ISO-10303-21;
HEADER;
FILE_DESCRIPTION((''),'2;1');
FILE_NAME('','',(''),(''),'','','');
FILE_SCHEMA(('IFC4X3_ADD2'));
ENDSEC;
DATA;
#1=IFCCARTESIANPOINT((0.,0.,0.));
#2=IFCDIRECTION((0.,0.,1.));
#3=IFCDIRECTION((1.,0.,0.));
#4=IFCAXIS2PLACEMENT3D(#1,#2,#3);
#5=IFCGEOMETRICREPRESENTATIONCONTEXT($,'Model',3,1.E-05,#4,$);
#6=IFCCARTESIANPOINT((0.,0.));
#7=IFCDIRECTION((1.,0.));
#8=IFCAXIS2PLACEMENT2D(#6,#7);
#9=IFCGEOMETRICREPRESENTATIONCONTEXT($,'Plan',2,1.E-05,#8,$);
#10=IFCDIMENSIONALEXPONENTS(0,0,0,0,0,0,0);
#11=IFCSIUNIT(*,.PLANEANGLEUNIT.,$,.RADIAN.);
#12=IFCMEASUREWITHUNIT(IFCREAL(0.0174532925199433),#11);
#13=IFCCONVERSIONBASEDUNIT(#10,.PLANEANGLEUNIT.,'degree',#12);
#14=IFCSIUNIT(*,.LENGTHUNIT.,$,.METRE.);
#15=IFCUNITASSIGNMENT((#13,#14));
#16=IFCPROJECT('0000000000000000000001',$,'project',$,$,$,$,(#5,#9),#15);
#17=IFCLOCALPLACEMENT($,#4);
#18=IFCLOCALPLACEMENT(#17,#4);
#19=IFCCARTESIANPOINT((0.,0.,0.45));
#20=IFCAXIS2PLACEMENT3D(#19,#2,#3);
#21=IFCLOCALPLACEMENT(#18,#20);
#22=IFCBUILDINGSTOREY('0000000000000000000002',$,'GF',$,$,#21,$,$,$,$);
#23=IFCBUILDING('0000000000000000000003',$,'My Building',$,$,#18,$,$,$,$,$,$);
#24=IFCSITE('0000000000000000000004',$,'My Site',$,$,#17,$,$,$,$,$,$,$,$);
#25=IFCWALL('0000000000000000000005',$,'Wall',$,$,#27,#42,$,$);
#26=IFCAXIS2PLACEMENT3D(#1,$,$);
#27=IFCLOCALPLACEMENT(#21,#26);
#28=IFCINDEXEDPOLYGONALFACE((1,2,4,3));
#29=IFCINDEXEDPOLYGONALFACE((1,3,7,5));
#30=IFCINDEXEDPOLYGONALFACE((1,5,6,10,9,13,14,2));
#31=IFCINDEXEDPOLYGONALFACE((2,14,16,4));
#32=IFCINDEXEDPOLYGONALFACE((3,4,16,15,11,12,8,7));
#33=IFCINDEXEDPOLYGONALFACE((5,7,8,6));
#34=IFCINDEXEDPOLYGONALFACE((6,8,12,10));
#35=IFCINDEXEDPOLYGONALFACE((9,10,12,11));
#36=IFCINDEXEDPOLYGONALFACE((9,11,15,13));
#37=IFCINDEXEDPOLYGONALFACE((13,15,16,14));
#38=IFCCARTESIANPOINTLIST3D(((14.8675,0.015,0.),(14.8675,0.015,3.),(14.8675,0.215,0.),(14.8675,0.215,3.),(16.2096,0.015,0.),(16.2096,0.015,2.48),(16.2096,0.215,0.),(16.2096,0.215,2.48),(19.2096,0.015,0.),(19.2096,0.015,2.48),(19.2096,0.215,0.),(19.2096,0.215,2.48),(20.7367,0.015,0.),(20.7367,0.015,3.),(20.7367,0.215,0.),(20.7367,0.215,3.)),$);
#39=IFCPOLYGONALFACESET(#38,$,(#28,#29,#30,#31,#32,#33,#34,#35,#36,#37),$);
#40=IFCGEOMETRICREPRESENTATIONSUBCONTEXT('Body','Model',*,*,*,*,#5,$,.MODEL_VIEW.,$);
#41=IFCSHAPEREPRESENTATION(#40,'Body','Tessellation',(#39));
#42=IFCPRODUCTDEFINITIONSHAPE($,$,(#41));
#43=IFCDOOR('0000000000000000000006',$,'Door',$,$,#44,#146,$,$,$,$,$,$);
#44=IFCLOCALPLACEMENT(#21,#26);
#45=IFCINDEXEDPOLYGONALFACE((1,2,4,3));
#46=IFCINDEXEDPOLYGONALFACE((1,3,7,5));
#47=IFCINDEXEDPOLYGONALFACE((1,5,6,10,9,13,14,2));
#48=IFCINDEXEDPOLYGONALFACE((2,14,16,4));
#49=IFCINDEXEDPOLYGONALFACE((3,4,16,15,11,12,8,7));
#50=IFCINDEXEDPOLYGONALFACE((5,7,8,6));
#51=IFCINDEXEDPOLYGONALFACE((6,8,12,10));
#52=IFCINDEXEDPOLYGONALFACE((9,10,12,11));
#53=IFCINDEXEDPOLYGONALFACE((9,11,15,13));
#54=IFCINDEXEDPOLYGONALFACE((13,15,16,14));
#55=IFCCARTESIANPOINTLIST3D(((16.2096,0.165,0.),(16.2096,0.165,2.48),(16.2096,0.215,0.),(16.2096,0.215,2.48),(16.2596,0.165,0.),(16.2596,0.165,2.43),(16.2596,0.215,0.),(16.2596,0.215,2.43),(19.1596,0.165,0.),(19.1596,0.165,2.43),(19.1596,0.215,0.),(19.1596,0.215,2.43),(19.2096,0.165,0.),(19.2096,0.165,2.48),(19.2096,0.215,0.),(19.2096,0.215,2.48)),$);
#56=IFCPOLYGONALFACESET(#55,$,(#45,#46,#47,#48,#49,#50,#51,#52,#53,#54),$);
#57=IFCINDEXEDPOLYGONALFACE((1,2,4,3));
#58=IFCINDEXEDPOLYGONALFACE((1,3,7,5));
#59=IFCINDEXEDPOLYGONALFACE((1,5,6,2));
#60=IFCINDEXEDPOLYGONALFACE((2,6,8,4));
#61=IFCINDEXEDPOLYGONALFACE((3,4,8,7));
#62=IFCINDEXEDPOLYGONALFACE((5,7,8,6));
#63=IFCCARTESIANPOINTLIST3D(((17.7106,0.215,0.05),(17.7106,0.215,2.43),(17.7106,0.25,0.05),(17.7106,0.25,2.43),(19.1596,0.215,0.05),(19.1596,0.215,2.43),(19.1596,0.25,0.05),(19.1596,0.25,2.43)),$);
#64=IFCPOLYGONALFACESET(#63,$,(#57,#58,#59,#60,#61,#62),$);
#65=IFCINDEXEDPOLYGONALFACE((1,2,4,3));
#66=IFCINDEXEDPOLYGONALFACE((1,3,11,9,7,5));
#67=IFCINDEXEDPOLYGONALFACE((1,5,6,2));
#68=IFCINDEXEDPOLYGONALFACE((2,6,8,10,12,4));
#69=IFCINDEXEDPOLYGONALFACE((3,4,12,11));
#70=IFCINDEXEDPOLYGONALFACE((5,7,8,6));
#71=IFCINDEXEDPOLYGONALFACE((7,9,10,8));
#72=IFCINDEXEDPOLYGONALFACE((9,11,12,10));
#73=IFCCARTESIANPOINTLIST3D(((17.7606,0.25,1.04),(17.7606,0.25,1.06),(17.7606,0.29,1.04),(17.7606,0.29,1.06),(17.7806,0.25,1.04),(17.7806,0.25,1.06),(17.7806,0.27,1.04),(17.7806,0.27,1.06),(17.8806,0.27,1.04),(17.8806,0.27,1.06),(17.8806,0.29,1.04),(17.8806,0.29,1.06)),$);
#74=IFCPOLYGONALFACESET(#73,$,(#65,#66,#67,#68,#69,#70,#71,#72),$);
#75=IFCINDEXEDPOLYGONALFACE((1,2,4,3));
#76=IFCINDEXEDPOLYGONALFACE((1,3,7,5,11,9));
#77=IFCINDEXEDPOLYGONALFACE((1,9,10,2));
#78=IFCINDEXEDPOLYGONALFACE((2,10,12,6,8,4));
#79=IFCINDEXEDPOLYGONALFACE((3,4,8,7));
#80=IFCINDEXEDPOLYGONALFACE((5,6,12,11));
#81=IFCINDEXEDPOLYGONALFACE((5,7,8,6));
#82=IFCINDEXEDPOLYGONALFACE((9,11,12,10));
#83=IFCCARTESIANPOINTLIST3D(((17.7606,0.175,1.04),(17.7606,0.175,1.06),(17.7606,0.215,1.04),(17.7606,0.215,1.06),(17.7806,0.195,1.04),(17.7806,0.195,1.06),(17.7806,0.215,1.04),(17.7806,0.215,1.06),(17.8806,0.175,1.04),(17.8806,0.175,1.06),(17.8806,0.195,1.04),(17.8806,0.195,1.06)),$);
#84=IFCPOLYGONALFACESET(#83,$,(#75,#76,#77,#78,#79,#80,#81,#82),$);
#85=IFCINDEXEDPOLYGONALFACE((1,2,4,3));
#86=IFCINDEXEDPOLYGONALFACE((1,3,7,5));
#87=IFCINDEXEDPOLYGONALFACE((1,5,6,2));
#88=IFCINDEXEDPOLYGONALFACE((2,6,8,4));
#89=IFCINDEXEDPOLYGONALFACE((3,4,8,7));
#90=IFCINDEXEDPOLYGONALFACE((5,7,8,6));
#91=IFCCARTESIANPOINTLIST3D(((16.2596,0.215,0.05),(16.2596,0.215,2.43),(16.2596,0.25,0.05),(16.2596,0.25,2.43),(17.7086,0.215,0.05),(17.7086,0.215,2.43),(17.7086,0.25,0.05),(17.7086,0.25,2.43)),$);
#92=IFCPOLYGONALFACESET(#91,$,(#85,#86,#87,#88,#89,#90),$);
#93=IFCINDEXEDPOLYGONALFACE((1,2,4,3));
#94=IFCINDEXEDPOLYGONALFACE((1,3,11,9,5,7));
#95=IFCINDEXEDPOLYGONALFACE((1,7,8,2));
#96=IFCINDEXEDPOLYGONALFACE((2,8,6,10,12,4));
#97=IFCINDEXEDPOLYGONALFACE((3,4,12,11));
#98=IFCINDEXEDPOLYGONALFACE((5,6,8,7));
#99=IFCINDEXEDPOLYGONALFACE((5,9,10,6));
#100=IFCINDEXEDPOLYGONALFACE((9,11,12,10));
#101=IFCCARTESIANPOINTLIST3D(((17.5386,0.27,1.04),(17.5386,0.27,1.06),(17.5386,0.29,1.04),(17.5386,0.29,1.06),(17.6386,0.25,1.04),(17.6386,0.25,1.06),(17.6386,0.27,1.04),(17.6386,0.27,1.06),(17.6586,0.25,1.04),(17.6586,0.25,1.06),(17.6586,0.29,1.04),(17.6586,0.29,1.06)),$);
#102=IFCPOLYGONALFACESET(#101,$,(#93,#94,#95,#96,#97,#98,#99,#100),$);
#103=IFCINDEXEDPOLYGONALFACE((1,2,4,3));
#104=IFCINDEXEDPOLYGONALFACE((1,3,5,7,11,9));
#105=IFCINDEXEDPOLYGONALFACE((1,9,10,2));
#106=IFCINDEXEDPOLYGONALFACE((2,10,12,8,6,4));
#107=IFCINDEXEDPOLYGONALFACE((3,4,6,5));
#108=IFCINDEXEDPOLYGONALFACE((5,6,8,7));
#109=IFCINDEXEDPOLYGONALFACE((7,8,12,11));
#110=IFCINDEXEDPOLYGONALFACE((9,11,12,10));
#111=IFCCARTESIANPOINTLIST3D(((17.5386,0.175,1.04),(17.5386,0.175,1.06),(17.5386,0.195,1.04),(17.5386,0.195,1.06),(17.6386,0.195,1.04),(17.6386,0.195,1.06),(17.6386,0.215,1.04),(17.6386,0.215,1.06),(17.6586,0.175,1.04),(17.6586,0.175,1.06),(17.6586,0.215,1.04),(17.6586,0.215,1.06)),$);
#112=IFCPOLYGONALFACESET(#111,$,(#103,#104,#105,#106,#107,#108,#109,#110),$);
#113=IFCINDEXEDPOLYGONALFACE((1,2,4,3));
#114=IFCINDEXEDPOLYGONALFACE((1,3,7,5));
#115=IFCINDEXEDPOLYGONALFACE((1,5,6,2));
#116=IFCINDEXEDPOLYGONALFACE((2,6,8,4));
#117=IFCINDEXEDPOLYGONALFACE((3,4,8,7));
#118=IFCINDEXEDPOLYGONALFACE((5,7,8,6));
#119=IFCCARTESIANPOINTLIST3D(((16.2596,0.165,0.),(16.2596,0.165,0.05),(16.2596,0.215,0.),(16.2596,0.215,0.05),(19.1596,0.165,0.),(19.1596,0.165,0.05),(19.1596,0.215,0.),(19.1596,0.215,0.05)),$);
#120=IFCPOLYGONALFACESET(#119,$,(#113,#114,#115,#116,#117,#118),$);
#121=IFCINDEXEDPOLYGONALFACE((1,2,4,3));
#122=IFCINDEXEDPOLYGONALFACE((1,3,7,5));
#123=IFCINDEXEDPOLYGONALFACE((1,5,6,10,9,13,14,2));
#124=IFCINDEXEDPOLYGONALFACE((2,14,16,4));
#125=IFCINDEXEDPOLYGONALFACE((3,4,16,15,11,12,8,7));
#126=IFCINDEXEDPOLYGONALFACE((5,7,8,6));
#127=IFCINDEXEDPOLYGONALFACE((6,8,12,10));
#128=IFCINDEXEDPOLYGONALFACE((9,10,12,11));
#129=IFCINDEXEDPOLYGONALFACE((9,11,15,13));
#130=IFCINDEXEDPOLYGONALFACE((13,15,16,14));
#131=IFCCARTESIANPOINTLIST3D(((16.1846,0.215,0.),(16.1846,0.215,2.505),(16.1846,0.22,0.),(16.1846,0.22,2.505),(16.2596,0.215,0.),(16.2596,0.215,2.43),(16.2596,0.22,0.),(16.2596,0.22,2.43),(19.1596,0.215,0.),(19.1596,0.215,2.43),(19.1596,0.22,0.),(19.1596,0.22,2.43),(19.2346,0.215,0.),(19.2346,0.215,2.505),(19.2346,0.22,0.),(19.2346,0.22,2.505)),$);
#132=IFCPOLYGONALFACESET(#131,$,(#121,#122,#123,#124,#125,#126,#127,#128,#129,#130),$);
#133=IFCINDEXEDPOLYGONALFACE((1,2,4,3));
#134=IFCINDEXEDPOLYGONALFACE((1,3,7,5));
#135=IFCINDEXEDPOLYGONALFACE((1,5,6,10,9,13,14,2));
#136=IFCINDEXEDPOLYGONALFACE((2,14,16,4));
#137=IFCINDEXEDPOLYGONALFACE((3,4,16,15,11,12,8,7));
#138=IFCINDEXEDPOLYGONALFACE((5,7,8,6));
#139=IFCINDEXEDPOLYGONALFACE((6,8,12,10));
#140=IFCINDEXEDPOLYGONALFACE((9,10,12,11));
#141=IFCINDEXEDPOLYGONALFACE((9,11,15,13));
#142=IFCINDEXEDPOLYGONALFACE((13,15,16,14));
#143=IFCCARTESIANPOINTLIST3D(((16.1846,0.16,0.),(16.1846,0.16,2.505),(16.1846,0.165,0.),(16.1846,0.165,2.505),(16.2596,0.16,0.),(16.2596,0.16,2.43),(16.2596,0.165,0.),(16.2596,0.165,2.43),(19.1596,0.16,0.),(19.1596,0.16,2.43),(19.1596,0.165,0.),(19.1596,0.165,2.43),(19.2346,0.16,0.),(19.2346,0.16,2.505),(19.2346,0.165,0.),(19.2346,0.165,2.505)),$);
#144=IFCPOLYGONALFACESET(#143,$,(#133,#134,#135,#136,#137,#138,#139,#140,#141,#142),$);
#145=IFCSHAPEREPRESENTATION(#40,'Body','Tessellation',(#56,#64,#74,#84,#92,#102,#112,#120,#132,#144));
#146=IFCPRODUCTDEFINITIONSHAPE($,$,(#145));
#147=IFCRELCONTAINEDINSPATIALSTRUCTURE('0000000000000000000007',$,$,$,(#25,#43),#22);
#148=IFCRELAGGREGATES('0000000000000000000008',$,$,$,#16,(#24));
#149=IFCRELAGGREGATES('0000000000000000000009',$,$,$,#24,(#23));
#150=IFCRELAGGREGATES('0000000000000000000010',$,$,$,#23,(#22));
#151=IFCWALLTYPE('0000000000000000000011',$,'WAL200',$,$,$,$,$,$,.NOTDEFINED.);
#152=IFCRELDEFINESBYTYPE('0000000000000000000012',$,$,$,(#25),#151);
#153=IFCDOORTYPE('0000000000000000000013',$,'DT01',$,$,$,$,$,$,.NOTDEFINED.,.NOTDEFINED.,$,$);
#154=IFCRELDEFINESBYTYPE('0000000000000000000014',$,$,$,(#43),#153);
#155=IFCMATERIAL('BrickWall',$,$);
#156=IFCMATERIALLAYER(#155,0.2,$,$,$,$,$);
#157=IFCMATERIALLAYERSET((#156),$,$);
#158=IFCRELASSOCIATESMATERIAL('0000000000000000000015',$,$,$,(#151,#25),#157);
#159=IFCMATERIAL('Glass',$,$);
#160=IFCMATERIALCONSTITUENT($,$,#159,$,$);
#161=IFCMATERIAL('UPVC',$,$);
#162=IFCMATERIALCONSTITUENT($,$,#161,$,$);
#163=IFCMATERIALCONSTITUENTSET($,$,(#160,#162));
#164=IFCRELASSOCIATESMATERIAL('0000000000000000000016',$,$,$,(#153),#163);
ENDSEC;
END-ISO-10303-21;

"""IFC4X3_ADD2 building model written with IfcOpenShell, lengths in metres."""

from ifc_helpers import new_model, entity, si_unit, converted_unit, frame, origin_with_axes, origin_2d_with_axis, place, context, subcontext, project, spatial, line, indexed_curve, outline, extrude, shape, source, transform, mapped, material, layer, layer_set, layer_usage, constituent, constituent_set, type_object, type_shapes, element, fill, save


model = new_model("IFC4X3_ADD2")

# Units and contexts
model_context = context("Model", 3, precision=1e-05, world=origin_with_axes())
plan_context = context("Plan", 2, precision=1e-05, world=origin_2d_with_axis())
body_context_1 = subcontext(model_context, "Body", "Model", "MODEL_VIEW")
body_context_2 = subcontext(plan_context, "Body", "Plan", "PLAN_VIEW")
ifc_project = project(units=[converted_unit("PLANEANGLEUNIT", "degree", entity("IfcReal", 0.0174532925199433), si_unit("PLANEANGLEUNIT", "RADIAN"), dimensions=[0, 0, 0, 0, 0, 0, 0]), si_unit("LENGTHUNIT", "METRE")], contexts=[model_context, plan_context])

# Site, building, storey
site_placement = place(None, origin_with_axes())
site = spatial("IfcSite", under=ifc_project, at=site_placement, Name="My Site")
building_placement = place(site_placement, origin_with_axes())
building = spatial("IfcBuilding", under=site, at=building_placement, Name="My Building")
storey_placement = place(building_placement, frame((0.0, 0.0, 0.45), z_axis=(0.0, 0.0, 1.0), x_axis=(1.0, 0.0, 0.0)))
storey = spatial("IfcBuildingStorey", under=building, at=storey_placement, Name="GF")

# Shared definitions
ifc_material_1 = material(Name="BrickWall")
ifc_layer_1 = layer(ifc_material_1, 0.2)
ifc_layer_set_1 = layer_set([ifc_layer_1])
wall_type_1 = type_object("IfcWallType", Name="WAL200", PredefinedType="NOTDEFINED", material=ifc_layer_set_1)
shared_shape_1 = source(origin_with_axes(), body_context_1, "Body", "SweptSolid", [
    extrude(outline(indexed_curve([(0.0, 0.0), (3.0, 0.0), (3.0, 2.48), (0.0, 2.48)], segments=[line(1, 2, 3, 4, 1)])), frame((0.0, -0.6, 0.0), z_axis=(0.0, -1.0, 0.0), x_axis=(1.0, 0.0, 0.0)), (0.0, 0.0, -1.0), 1.2),
])
ifc_material_2 = material(Name="Glass")
ifc_constituent_1 = constituent(ifc_material_2)
ifc_material_3 = material(Name="UPVC")
ifc_constituent_2 = constituent(ifc_material_3)
ifc_constituent_set = constituent_set(constituents=[ifc_constituent_1, ifc_constituent_2])
door_type_1 = type_object("IfcDoorType", Name="DT01", OperationType="NOTDEFINED", PredefinedType="NOTDEFINED", material=ifc_constituent_set)
shared_shape_2 = source(origin_with_axes(), body_context_1, "Body", "SweptSolid", [
    extrude(outline(indexed_curve([(3.0, 0.0), (3.0, 2.48), (0.0, 2.48), (0.0, 0.0), (0.05, 0.0), (0.05, 2.43), (2.95, 2.43), (2.95, 0.0)], segments=[line(5, 4), line(4, 3), line(3, 2), line(2, 1), line(1, 8), line(8, 7), line(7, 6), line(6, 5)], self_intersect=False)), frame((0.0, 0.0, 0.0), z_axis=(0.0, -1.0, 0.0), x_axis=(1.0, 0.0, 0.0)), (0.0, 0.0, -1.0), 0.05),
    extrude(outline(indexed_curve([(0.0, 0.0), (1.449, 0.0), (1.449, 0.035), (0.0, 0.035)], segments=[line(1, 2, 3, 4, 1)])), frame((0.05, -0.035, 0.05), z_axis=(0.0, 0.0, 1.0), x_axis=(1.0, 0.0, 0.0)), (0.0, 0.0, 1.0), 2.38),
    extrude(outline(indexed_curve([(0.0, 0.0), (0.0, -0.04), (-0.12, -0.04), (-0.12, -0.02), (-0.02, -0.02), (-0.02, 0.0)], segments=[line(1, 2, 3, 4, 5, 6, 1)])), frame((1.449, -0.035, 1.04), z_axis=(0.0, 0.0, 1.0), x_axis=(1.0, 0.0, 0.0)), (0.0, 0.0, 1.0), 0.02),
    extrude(outline(indexed_curve([(0.0, 0.0), (0.0, 0.04), (-0.12, 0.04), (-0.12, 0.02), (-0.02, 0.02), (-0.02, 0.0)], segments=[line(1, 2, 3, 4, 5, 6, 1)])), frame((1.449, 0.0, 1.04), z_axis=(0.0, 0.0, 1.0), x_axis=(1.0, 0.0, 0.0)), (0.0, 0.0, 1.0), 0.02),
    extrude(outline(indexed_curve([(0.0, 0.0), (-1.449, 0.0), (-1.449, 0.035), (0.0, 0.035)], segments=[line(1, 2, 3, 4, 1)])), frame((2.95, -0.035, 0.05), z_axis=(0.0, 0.0, 1.0), x_axis=(1.0, 0.0, 0.0)), (0.0, 0.0, 1.0), 2.38),
    extrude(outline(indexed_curve([(0.0, 0.0), (0.0, -0.04), (0.12, -0.04), (0.12, -0.02), (0.02, -0.02), (0.02, 0.0)], segments=[line(1, 2, 3, 4, 5, 6, 1)])), frame((1.551, -0.035, 1.04), z_axis=(0.0, 0.0, 1.0), x_axis=(1.0, 0.0, 0.0)), (0.0, 0.0, 1.0), 0.02),
    extrude(outline(indexed_curve([(0.0, 0.0), (0.0, 0.04), (0.12, 0.04), (0.12, 0.02), (0.02, 0.02), (0.02, 0.0)], segments=[line(1, 2, 3, 4, 5, 6, 1)])), frame((1.551, 0.0, 1.04), z_axis=(0.0, 0.0, 1.0), x_axis=(1.0, 0.0, 0.0)), (0.0, 0.0, 1.0), 0.02),
    extrude(outline(indexed_curve([(0.0, 0.0), (2.9, 0.0), (2.9, 0.05), (0.0, 0.05)], segments=[line(1, 2, 3, 4, 1)])), frame((0.05, 0.0, 0.0), z_axis=(0.0, 0.0, 1.0), x_axis=(1.0, 0.0, 0.0)), (0.0, 0.0, 1.0), 0.05),
    extrude(outline(indexed_curve([(0.0, 0.0), (0.0, 2.505), (3.05, 2.505), (3.05, 0.0), (2.975, 0.0), (2.975, 2.43), (0.075, 2.43), (0.075, 0.0)], segments=[line(1, 2, 3, 4, 5, 6, 7, 8, 1)])), frame((-0.025, -0.005, 0.0), z_axis=(0.0, -1.0, 0.0), x_axis=(1.0, 0.0, 0.0)), (0.0, 0.0, -1.0), 0.005),
    extrude(outline(indexed_curve([(0.0, 0.0), (0.0, 2.505), (3.05, 2.505), (3.05, 0.0), (2.975, 0.0), (2.975, 2.43), (0.075, 2.43), (0.075, 0.0)], segments=[line(1, 2, 3, 4, 5, 6, 7, 8, 1)])), frame((-0.025, 0.05, 0.0), z_axis=(0.0, -1.0, 0.0), x_axis=(1.0, 0.0, 0.0)), (0.0, 0.0, -1.0), 0.005),
])
shared_shape_3 = source(origin_with_axes(), body_context_2, "Body", "Curve2D", [
    entity("IfcIndexedPolyCurve", entity("IfcCartesianPointList2D", [[0.0, 0.0], [0.05, 0.0], [0.05, 0.05], [0.0, 0.05]]), [entity("IfcLineIndex", [1, 2, 3, 4, 1])]),
    entity("IfcIndexedPolyCurve", entity("IfcCartesianPointList2D", [[3.0, 0.0], [2.95, 0.0], [2.95, 0.05], [3.0, 0.05]]), [entity("IfcLineIndex", [1, 2, 3, 4, 1])]),
    entity("IfcIndexedPolyCurve", entity("IfcCartesianPointList2D", [[-0.675, -0.035], [0.775, -0.035], [0.775, 0.0], [-0.675, 0.0]]), [entity("IfcLineIndex", [1, 2, 3, 4, 1])]),
    entity("IfcIndexedPolyCurve", entity("IfcCartesianPointList2D", [[3.675, -0.035], [2.225, -0.035], [2.225, 0.0], [3.675, 0.0]]), [entity("IfcLineIndex", [1, 2, 3, 4, 1])]),
])
type_shapes(door_type_1, [shared_shape_2, shared_shape_3])

# Wall, opening, door
ifc_layer_usage_1 = layer_usage(ifc_layer_set_1, "AXIS2", "POSITIVE", 0.0)
wall_1_placement = place(storey_placement, frame((20.7367, 0.215, 0.0), z_axis=(0.0, 0.0, 1.0), x_axis=(-1.0, 0.0, 0.0)))
wall_1 = element("IfcWall", 1, at=wall_1_placement, inside=storey, type_object=wall_type_1, material=ifc_layer_usage_1, Name="Wall", context=body_context_1, shape_type="SweptSolid", body=[
    extrude(outline(indexed_curve([(0.0, 0.0), (0.0, 0.2), (5.8693, 0.2), (5.8693, 0.0), (0.0, 0.0)], self_intersect=False)), origin_with_axes(), (0.0, 0.0, 1.0), 3.0),
])
opening_1_placement = place(wall_1_placement, frame((1.5272, 0.0, 0.0), z_axis=(0.0, 0.0, 1.0), x_axis=(1.0, 0.0, 0.0)))
opening_1 = element("IfcOpeningElement", 2, at=opening_1_placement, cuts=wall_1, PredefinedType="OPENING", context=body_context_1, shape_type="MappedRepresentation", body=[
    mapped(shared_shape_1, transform((0.0, 0.0, 0.0), x_axis=(1.0, 0.0, 0.0), y_axis=(0.0, 1.0, 0.0), z_axis=(0.0, 0.0, 1.0), scale=1.0)),
])
door_1_placement = place(opening_1_placement, frame((0.0, 0.0, 0.0), z_axis=(0.0, 0.0, 1.0), x_axis=(1.0, 0.0, 0.0)))
door_1 = element("IfcDoor", 3, at=door_1_placement, inside=storey, type_object=door_type_1, Name="Door", shapes=[
    shape(body_context_1, "Body", "MappedRepresentation", [mapped(shared_shape_2, transform((0.0, 0.0, 0.0), x_axis=(1.0, 0.0, 0.0), y_axis=(0.0, 1.0, 0.0), z_axis=(0.0, 0.0, 1.0), scale=1.0))]),
    shape(body_context_2, "Body", "MappedRepresentation", [mapped(shared_shape_3, transform((0.0, 0.0, 0.0), x_axis=(1.0, 0.0, 0.0), y_axis=(0.0, 1.0, 0.0), z_axis=(0.0, 0.0, 1.0), scale=1.0))]),
])
fill(opening_1, door_1)

save(model, "model.ifc")
